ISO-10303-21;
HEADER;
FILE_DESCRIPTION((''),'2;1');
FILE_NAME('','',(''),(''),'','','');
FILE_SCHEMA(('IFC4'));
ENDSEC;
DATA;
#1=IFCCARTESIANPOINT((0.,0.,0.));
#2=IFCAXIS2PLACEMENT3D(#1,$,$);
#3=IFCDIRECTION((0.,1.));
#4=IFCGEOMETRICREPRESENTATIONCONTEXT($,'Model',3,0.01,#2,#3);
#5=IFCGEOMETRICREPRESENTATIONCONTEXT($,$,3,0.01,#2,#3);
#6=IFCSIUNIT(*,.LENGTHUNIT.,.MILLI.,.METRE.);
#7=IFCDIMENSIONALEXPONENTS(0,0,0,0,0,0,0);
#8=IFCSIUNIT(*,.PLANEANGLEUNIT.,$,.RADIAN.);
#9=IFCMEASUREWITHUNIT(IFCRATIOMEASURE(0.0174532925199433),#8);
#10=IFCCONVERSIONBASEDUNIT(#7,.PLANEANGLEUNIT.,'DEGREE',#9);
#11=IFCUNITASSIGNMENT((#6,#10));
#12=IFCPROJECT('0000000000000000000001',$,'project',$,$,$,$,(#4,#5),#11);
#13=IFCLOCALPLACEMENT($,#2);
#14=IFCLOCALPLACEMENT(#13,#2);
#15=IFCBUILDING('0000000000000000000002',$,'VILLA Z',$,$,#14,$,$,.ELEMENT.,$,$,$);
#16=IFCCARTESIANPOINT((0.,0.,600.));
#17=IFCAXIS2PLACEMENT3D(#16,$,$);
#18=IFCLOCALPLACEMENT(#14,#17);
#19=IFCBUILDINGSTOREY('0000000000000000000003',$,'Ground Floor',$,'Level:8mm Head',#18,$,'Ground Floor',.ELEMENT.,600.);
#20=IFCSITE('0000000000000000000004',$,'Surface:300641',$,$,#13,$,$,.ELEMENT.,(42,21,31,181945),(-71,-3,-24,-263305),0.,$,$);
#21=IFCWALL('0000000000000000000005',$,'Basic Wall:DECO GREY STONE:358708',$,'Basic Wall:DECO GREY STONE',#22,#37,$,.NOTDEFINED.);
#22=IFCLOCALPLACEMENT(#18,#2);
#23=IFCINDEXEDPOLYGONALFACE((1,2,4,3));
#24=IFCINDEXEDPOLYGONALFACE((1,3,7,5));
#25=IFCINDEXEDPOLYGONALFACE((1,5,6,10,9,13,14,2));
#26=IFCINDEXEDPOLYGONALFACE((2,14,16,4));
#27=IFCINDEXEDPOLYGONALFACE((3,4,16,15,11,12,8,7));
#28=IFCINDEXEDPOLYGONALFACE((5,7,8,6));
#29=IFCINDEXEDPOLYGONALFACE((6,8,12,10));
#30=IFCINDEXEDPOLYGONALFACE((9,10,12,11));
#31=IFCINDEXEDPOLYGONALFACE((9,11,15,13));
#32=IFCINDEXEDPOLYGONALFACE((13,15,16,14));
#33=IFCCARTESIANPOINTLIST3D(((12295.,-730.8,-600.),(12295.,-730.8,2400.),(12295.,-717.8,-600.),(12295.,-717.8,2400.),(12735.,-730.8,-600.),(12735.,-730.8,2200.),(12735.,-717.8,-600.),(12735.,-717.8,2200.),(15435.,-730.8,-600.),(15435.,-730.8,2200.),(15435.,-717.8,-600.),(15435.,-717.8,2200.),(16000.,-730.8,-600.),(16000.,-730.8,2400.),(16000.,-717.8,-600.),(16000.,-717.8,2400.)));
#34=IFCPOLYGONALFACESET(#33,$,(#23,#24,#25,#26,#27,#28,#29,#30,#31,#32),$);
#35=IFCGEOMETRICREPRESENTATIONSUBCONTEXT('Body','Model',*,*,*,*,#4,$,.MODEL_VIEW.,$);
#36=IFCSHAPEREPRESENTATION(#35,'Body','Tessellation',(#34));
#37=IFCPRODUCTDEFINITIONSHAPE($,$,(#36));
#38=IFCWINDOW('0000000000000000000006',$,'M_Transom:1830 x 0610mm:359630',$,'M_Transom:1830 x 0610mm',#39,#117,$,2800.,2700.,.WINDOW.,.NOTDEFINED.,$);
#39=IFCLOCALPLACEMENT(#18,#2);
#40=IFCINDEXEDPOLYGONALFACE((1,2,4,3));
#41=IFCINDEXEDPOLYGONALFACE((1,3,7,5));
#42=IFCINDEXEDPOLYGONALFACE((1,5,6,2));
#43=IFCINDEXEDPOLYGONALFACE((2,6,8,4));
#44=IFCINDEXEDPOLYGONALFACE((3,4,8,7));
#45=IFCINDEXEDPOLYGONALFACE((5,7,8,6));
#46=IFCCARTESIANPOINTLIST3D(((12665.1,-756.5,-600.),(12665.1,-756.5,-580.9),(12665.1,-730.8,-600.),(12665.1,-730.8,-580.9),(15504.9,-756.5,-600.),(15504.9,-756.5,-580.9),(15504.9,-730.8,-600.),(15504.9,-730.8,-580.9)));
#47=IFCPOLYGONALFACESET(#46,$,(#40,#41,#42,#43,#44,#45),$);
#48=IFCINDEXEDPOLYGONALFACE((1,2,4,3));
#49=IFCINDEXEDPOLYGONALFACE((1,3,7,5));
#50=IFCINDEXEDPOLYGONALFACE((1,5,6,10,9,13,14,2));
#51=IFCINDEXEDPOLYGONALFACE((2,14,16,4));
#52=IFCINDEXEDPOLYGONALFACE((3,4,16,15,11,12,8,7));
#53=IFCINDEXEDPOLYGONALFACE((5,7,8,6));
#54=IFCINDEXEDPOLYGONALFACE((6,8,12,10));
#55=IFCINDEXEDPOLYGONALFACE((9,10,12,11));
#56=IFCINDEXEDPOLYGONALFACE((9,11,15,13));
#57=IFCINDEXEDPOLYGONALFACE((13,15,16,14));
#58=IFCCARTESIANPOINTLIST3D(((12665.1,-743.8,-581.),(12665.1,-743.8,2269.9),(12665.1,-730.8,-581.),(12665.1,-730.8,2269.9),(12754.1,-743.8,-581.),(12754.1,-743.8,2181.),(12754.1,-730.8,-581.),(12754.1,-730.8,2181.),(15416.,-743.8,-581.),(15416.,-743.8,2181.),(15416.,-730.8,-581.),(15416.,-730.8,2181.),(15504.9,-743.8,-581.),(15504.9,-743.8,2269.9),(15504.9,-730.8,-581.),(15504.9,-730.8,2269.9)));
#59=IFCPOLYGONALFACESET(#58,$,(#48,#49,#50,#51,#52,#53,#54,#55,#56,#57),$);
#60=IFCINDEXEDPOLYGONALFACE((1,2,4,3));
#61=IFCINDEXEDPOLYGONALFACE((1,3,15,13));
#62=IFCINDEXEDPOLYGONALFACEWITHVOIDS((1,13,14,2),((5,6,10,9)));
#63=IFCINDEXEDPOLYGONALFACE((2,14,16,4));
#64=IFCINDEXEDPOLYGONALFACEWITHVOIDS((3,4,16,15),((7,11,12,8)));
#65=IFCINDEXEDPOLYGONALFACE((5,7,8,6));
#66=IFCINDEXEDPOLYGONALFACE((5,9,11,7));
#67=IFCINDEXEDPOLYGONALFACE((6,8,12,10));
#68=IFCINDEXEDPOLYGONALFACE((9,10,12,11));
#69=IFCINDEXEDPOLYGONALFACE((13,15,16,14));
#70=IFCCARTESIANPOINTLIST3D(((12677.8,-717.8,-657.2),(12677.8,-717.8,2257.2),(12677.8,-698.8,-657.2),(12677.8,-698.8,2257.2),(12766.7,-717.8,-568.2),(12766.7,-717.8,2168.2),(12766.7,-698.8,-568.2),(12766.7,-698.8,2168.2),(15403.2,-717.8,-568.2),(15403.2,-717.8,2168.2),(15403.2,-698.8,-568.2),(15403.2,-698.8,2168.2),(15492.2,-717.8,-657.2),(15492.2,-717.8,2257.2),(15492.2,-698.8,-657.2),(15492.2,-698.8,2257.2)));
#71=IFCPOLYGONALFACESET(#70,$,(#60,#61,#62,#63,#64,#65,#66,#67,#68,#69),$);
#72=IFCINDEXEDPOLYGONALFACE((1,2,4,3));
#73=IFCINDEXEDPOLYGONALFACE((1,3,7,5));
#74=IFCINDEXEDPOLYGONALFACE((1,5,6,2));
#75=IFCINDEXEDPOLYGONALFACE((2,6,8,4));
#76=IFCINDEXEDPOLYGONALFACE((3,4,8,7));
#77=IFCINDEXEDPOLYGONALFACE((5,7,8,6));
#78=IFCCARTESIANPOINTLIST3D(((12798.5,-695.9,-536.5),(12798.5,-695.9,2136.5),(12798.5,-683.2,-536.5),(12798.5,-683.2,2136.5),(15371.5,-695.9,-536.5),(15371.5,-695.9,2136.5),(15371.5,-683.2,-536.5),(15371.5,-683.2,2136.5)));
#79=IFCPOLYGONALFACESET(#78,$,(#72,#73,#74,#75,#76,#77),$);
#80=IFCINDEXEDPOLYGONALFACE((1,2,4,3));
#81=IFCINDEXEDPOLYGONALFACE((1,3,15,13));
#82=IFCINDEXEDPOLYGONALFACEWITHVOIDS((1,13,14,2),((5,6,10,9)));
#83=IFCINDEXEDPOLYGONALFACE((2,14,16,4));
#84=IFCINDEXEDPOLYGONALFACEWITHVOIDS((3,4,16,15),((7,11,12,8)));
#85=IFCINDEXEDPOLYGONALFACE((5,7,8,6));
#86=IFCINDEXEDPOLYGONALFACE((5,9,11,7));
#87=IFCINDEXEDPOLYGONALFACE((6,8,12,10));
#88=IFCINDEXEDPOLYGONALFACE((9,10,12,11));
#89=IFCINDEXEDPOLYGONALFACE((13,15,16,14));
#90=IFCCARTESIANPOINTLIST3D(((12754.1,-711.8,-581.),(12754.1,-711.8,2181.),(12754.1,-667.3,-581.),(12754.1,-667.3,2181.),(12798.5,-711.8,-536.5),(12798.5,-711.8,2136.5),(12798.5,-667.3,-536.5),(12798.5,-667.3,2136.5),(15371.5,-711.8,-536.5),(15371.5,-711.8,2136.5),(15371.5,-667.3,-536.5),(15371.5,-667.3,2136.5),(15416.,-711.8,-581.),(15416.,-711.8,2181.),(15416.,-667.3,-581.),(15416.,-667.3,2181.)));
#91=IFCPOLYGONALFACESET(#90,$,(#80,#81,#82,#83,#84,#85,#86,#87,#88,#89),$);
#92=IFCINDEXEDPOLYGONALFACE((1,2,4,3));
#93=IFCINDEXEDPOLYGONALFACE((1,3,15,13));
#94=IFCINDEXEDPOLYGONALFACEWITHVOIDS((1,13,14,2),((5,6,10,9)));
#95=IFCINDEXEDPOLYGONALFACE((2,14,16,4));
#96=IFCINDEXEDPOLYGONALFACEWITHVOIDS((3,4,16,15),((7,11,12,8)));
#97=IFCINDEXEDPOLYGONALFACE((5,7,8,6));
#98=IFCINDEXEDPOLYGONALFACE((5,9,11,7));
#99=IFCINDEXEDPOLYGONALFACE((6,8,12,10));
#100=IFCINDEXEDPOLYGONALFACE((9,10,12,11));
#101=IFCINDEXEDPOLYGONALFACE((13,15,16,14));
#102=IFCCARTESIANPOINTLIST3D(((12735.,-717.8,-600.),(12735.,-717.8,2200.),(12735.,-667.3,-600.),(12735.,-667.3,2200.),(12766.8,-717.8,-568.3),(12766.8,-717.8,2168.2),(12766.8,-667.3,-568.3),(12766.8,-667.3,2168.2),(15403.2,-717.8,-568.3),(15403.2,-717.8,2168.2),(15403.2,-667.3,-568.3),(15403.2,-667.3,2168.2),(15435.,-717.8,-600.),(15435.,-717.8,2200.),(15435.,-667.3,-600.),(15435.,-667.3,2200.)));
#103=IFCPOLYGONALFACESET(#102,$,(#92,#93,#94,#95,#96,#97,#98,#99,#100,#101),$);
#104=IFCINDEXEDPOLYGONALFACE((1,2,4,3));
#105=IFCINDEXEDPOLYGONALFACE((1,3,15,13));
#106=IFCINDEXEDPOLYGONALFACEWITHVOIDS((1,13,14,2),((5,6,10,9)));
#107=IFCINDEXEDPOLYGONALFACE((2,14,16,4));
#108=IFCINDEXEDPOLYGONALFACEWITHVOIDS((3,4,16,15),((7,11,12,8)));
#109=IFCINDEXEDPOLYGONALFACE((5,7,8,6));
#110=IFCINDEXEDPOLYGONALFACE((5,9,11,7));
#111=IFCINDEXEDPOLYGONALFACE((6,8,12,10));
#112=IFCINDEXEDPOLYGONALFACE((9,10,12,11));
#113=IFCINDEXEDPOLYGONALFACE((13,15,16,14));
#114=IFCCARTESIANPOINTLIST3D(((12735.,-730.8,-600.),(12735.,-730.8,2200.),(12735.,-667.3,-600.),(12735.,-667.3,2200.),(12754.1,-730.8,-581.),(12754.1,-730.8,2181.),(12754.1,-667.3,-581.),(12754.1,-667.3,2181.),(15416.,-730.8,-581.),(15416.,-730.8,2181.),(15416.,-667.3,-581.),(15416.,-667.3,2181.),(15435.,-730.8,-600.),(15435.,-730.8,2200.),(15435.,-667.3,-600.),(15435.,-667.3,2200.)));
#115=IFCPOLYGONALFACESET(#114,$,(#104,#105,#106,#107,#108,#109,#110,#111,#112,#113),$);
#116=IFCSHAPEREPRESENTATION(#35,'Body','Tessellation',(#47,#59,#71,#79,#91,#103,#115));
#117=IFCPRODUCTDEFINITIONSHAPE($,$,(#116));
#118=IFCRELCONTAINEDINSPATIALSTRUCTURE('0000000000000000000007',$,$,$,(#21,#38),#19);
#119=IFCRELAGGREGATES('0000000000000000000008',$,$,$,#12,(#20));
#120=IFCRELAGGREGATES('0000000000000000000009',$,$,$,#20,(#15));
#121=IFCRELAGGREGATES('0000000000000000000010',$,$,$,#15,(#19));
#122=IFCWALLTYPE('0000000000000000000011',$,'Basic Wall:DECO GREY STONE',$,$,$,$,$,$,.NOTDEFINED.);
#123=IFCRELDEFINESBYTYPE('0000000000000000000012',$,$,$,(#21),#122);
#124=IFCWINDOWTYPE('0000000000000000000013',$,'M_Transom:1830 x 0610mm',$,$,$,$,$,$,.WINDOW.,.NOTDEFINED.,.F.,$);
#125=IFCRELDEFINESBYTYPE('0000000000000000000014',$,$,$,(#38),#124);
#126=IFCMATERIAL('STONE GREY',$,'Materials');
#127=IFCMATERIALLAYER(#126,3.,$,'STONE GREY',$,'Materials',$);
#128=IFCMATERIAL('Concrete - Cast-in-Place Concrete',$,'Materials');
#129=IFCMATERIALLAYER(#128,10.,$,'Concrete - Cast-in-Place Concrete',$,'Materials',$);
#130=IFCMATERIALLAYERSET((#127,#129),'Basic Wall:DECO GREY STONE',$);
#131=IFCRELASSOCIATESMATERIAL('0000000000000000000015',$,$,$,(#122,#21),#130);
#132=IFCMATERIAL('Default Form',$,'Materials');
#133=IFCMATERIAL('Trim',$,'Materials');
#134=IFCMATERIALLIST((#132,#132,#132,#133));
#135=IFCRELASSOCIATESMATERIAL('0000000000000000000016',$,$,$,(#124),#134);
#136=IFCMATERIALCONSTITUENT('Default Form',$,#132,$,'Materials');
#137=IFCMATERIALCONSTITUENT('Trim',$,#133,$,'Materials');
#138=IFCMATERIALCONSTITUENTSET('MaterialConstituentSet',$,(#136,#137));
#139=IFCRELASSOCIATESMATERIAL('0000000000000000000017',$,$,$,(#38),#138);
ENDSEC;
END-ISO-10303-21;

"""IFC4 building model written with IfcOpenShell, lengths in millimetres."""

from ifc_helpers import new_model, entity, si_unit, converted_unit, direction, frame, frame_2d, origin, place, context, subcontext, project, spatial, polyline, rectangle, outline, extrude, source, transform, mapped, material, material_list, layer, layer_set, layer_usage, constituent, constituent_set, type_object, type_shapes, element, fill, save


model = new_model("IFC4")

# Units and contexts
model_context = context("Model", 3, precision=0.01, world=origin(), true_north=direction((0.0, 1.0)))
context_of_model = context(None, 3, precision=0.01, world=origin(), true_north=direction((0.0, 1.0)))
body_context = subcontext(model_context, "Body", "Model", "MODEL_VIEW")
ifc_project = project(units=[si_unit("LENGTHUNIT", "METRE", prefix="MILLI"), converted_unit("PLANEANGLEUNIT", "DEGREE", entity("IfcRatioMeasure", 0.0174532925199433), si_unit("PLANEANGLEUNIT", "RADIAN"), dimensions=[0, 0, 0, 0, 0, 0, 0])], contexts=[model_context, context_of_model])

# Site, building, storey
site_placement = place(None, origin())
site = spatial("IfcSite", under=ifc_project, at=site_placement, Name="Surface:300641", CompositionType="ELEMENT", RefLatitude=(42, 21, 31, 181945), RefLongitude=(-71, -3, -24, -263305), RefElevation=0.0)
building_placement = place(site_placement, origin())
building = spatial("IfcBuilding", under=site, at=building_placement, Name="VILLA Z", CompositionType="ELEMENT")
storey_placement = place(building_placement, frame((0.0, 0.0, 600.0)))
storey = spatial("IfcBuildingStorey", under=building, at=storey_placement, Name="Ground Floor", ObjectType="Level:8mm Head", LongName="Ground Floor", CompositionType="ELEMENT", Elevation=600.0)

# Shared definitions
ifc_material_1 = material(Name="Concrete - Cast-in-Place Concrete", Category="Materials")

# Wall, opening, window
ifc_material_2 = material(Name="STONE GREY", Category="Materials")
ifc_layer_1 = layer(ifc_material_2, 3.0, Name="STONE GREY", Category="Materials")
ifc_layer_2 = layer(ifc_material_1, 10.0, Name="Concrete - Cast-in-Place Concrete", Category="Materials")
ifc_layer_set_1 = layer_set([ifc_layer_1, ifc_layer_2], Name="Basic Wall:DECO GREY STONE")
ifc_layer_usage_1 = layer_usage(ifc_layer_set_1, "AXIS2", "POSITIVE", -6.5)
wall_type_1 = type_object("IfcWallType", Name="Basic Wall:DECO GREY STONE", PredefinedType="NOTDEFINED", material=ifc_layer_set_1)
wall_1_placement = place(storey_placement, frame((12295.0, -724.3, -600.0)))
wall_1 = element("IfcWall", 1, at=wall_1_placement, inside=storey, type_object=wall_type_1, material=ifc_layer_usage_1, Name="Basic Wall:DECO GREY STONE:358708", ObjectType="Basic Wall:DECO GREY STONE", PredefinedType="NOTDEFINED", context=body_context, shape_type="SweptSolid", body=[
    extrude(rectangle(XDim=3705.0, YDim=13.0, at=frame_2d((1852.5, 0.0), x_axis=(-1.0, 0.0))), origin(), (0.0, 0.0, 1.0), 3000.0),
])
opening_1_placement = place(wall_1_placement, frame((3140.0, 6.5, 0.0)))
opening_1 = element("IfcOpeningElement", 2, at=opening_1_placement, cuts=wall_1, ObjectType="Opening", PredefinedType="OPENING", context=body_context, shape_type="SweptSolid", body=[
    extrude(rectangle(XDim=2800.0, YDim=2700.0, at=frame_2d((1400.0, 1350.0), x_axis=(-1.0, 0.0))), frame((0.0, 0.0, 0.0), z_axis=(0.0, -1.0, 0.0), x_axis=(0.0, 0.0, 1.0)), (0.0, 0.0, 1.0), 13.0),
])
ifc_material_3 = material(Name="Default Form", Category="Materials")
ifc_constituent_1 = constituent(ifc_material_3, Name="Default Form", Category="Materials")
ifc_material_4 = material(Name="Trim", Category="Materials")
ifc_constituent_2 = constituent(ifc_material_4, Name="Trim", Category="Materials")
ifc_constituent_set = constituent_set(constituents=[ifc_constituent_1, ifc_constituent_2], Name="MaterialConstituentSet")
ifc_material_list = material_list([ifc_material_3, ifc_material_3, ifc_material_3, ifc_material_4])
window_type = type_object("IfcWindowType", Name="M_Transom:1830 x 0610mm", ParameterTakesPrecedence=False, PartitioningType="NOTDEFINED", PredefinedType="WINDOW", material=ifc_material_list)
shared_shape_1 = source(origin(), body_context, "Body", "SweptSolid", [
    extrude(rectangle(XDim=25.7, YDim=2839.9, at=frame_2d((0.0, 0.0), x_axis=(1.0, 0.0))), frame((1350.0, 25.9, 0.0), z_axis=(0.0, 0.0, 1.0), x_axis=(0.0, -1.0, 0.0)), (0.0, 0.0, 1.0), 19.1),
    extrude(outline(polyline([(-1358.7, 1331.0), (1403.2, 1331.0), (1403.2, 1419.9), (-1447.7, 1419.9), (-1447.7, -1419.9), (1403.2, -1419.9), (1403.2, -1330.9), (-1358.7, -1330.9), (-1358.7, 1331.0)])), frame((1350.0, 13.0, 1422.2), z_axis=(0.0, 1.0, 0.0), x_axis=(0.0, 0.0, -1.0)), (0.0, 0.0, 1.0), 13.0),
    extrude(outline(polyline([(-1457.2, -1407.2), (1457.2, -1407.2), (1457.2, 1407.2), (-1457.2, 1407.2), (-1457.2, -1407.2)]), holes=[polyline([(-1368.2, -1318.3), (-1368.2, 1318.2), (1368.2, 1318.2), (1368.2, -1318.3), (-1368.2, -1318.3)])]), frame((1350.0, -19.0, 1400.0), z_axis=(0.0, 1.0, 0.0), x_axis=(0.0, 0.0, -1.0)), (0.0, 0.0, 1.0), 19.0),
    extrude(rectangle(XDim=12.7, YDim=2573.0, at=frame_2d((0.0, 0.0), x_axis=(1.0, 0.0))), frame((1350.0, -28.2, 63.5), z_axis=(0.0, 0.0, 1.0), x_axis=(0.0, 1.0, 0.0)), (0.0, 0.0, 1.0), 2673.0),
    extrude(outline(polyline([(-1331.0, -1381.0), (1331.0, -1381.0), (1331.0, 1381.0), (-1331.0, 1381.0), (-1331.0, -1381.0)]), holes=[polyline([(-1286.5, -1336.5), (-1286.5, 1336.5), (1286.5, 1336.5), (1286.5, -1336.5), (-1286.5, -1336.5)])]), frame((1350.0, -50.5, 1400.0), z_axis=(0.0, 1.0, 0.0), x_axis=(1.0, 0.0, 0.0)), (0.0, 0.0, 1.0), 44.5),
    extrude(outline(polyline([(-1350.0, -1400.0), (1350.0, -1400.0), (1350.0, 1400.0), (-1350.0, 1400.0), (-1350.0, -1400.0)]), holes=[polyline([(-1318.2, -1368.2), (-1318.2, 1368.3), (1318.2, 1368.3), (1318.2, -1368.2), (-1318.2, -1368.2)])]), frame((1350.0, -50.5, 1400.0), z_axis=(0.0, 1.0, 0.0), x_axis=(1.0, 0.0, 0.0)), (0.0, 0.0, 1.0), 50.5),
    extrude(outline(polyline([(-1400.0, -1350.0), (1400.0, -1350.0), (1400.0, 1350.0), (-1400.0, 1350.0), (-1400.0, -1350.0)]), holes=[polyline([(-1381.0, -1331.0), (-1381.0, 1331.0), (1381.0, 1331.0), (1381.0, -1331.0), (-1381.0, -1331.0)])]), frame((1350.0, -50.5, 1400.0), z_axis=(0.0, 1.0, 0.0), x_axis=(0.0, 0.0, -1.0)), (0.0, 0.0, 1.0), 63.5),
])
type_shapes(window_type, [shared_shape_1])
window_placement = place(opening_1_placement, frame((0.0, 0.0, 0.0), z_axis=(0.0, 0.0, 1.0), x_axis=(-1.0, 0.0, 0.0)))
window = element("IfcWindow", 3, at=window_placement, inside=storey, type_object=window_type, material=ifc_constituent_set, Name="M_Transom:1830 x 0610mm:359630", ObjectType="M_Transom:1830 x 0610mm", OverallHeight=2800.0, OverallWidth=2700.0, PartitioningType="NOTDEFINED", PredefinedType="WINDOW", context=body_context, shape_type="MappedRepresentation", body=[
    mapped(shared_shape_1, transform((0.0, 0.0, 0.0), scale=1.0)),
])
fill(opening_1, window)

save(model, "model.ifc")
